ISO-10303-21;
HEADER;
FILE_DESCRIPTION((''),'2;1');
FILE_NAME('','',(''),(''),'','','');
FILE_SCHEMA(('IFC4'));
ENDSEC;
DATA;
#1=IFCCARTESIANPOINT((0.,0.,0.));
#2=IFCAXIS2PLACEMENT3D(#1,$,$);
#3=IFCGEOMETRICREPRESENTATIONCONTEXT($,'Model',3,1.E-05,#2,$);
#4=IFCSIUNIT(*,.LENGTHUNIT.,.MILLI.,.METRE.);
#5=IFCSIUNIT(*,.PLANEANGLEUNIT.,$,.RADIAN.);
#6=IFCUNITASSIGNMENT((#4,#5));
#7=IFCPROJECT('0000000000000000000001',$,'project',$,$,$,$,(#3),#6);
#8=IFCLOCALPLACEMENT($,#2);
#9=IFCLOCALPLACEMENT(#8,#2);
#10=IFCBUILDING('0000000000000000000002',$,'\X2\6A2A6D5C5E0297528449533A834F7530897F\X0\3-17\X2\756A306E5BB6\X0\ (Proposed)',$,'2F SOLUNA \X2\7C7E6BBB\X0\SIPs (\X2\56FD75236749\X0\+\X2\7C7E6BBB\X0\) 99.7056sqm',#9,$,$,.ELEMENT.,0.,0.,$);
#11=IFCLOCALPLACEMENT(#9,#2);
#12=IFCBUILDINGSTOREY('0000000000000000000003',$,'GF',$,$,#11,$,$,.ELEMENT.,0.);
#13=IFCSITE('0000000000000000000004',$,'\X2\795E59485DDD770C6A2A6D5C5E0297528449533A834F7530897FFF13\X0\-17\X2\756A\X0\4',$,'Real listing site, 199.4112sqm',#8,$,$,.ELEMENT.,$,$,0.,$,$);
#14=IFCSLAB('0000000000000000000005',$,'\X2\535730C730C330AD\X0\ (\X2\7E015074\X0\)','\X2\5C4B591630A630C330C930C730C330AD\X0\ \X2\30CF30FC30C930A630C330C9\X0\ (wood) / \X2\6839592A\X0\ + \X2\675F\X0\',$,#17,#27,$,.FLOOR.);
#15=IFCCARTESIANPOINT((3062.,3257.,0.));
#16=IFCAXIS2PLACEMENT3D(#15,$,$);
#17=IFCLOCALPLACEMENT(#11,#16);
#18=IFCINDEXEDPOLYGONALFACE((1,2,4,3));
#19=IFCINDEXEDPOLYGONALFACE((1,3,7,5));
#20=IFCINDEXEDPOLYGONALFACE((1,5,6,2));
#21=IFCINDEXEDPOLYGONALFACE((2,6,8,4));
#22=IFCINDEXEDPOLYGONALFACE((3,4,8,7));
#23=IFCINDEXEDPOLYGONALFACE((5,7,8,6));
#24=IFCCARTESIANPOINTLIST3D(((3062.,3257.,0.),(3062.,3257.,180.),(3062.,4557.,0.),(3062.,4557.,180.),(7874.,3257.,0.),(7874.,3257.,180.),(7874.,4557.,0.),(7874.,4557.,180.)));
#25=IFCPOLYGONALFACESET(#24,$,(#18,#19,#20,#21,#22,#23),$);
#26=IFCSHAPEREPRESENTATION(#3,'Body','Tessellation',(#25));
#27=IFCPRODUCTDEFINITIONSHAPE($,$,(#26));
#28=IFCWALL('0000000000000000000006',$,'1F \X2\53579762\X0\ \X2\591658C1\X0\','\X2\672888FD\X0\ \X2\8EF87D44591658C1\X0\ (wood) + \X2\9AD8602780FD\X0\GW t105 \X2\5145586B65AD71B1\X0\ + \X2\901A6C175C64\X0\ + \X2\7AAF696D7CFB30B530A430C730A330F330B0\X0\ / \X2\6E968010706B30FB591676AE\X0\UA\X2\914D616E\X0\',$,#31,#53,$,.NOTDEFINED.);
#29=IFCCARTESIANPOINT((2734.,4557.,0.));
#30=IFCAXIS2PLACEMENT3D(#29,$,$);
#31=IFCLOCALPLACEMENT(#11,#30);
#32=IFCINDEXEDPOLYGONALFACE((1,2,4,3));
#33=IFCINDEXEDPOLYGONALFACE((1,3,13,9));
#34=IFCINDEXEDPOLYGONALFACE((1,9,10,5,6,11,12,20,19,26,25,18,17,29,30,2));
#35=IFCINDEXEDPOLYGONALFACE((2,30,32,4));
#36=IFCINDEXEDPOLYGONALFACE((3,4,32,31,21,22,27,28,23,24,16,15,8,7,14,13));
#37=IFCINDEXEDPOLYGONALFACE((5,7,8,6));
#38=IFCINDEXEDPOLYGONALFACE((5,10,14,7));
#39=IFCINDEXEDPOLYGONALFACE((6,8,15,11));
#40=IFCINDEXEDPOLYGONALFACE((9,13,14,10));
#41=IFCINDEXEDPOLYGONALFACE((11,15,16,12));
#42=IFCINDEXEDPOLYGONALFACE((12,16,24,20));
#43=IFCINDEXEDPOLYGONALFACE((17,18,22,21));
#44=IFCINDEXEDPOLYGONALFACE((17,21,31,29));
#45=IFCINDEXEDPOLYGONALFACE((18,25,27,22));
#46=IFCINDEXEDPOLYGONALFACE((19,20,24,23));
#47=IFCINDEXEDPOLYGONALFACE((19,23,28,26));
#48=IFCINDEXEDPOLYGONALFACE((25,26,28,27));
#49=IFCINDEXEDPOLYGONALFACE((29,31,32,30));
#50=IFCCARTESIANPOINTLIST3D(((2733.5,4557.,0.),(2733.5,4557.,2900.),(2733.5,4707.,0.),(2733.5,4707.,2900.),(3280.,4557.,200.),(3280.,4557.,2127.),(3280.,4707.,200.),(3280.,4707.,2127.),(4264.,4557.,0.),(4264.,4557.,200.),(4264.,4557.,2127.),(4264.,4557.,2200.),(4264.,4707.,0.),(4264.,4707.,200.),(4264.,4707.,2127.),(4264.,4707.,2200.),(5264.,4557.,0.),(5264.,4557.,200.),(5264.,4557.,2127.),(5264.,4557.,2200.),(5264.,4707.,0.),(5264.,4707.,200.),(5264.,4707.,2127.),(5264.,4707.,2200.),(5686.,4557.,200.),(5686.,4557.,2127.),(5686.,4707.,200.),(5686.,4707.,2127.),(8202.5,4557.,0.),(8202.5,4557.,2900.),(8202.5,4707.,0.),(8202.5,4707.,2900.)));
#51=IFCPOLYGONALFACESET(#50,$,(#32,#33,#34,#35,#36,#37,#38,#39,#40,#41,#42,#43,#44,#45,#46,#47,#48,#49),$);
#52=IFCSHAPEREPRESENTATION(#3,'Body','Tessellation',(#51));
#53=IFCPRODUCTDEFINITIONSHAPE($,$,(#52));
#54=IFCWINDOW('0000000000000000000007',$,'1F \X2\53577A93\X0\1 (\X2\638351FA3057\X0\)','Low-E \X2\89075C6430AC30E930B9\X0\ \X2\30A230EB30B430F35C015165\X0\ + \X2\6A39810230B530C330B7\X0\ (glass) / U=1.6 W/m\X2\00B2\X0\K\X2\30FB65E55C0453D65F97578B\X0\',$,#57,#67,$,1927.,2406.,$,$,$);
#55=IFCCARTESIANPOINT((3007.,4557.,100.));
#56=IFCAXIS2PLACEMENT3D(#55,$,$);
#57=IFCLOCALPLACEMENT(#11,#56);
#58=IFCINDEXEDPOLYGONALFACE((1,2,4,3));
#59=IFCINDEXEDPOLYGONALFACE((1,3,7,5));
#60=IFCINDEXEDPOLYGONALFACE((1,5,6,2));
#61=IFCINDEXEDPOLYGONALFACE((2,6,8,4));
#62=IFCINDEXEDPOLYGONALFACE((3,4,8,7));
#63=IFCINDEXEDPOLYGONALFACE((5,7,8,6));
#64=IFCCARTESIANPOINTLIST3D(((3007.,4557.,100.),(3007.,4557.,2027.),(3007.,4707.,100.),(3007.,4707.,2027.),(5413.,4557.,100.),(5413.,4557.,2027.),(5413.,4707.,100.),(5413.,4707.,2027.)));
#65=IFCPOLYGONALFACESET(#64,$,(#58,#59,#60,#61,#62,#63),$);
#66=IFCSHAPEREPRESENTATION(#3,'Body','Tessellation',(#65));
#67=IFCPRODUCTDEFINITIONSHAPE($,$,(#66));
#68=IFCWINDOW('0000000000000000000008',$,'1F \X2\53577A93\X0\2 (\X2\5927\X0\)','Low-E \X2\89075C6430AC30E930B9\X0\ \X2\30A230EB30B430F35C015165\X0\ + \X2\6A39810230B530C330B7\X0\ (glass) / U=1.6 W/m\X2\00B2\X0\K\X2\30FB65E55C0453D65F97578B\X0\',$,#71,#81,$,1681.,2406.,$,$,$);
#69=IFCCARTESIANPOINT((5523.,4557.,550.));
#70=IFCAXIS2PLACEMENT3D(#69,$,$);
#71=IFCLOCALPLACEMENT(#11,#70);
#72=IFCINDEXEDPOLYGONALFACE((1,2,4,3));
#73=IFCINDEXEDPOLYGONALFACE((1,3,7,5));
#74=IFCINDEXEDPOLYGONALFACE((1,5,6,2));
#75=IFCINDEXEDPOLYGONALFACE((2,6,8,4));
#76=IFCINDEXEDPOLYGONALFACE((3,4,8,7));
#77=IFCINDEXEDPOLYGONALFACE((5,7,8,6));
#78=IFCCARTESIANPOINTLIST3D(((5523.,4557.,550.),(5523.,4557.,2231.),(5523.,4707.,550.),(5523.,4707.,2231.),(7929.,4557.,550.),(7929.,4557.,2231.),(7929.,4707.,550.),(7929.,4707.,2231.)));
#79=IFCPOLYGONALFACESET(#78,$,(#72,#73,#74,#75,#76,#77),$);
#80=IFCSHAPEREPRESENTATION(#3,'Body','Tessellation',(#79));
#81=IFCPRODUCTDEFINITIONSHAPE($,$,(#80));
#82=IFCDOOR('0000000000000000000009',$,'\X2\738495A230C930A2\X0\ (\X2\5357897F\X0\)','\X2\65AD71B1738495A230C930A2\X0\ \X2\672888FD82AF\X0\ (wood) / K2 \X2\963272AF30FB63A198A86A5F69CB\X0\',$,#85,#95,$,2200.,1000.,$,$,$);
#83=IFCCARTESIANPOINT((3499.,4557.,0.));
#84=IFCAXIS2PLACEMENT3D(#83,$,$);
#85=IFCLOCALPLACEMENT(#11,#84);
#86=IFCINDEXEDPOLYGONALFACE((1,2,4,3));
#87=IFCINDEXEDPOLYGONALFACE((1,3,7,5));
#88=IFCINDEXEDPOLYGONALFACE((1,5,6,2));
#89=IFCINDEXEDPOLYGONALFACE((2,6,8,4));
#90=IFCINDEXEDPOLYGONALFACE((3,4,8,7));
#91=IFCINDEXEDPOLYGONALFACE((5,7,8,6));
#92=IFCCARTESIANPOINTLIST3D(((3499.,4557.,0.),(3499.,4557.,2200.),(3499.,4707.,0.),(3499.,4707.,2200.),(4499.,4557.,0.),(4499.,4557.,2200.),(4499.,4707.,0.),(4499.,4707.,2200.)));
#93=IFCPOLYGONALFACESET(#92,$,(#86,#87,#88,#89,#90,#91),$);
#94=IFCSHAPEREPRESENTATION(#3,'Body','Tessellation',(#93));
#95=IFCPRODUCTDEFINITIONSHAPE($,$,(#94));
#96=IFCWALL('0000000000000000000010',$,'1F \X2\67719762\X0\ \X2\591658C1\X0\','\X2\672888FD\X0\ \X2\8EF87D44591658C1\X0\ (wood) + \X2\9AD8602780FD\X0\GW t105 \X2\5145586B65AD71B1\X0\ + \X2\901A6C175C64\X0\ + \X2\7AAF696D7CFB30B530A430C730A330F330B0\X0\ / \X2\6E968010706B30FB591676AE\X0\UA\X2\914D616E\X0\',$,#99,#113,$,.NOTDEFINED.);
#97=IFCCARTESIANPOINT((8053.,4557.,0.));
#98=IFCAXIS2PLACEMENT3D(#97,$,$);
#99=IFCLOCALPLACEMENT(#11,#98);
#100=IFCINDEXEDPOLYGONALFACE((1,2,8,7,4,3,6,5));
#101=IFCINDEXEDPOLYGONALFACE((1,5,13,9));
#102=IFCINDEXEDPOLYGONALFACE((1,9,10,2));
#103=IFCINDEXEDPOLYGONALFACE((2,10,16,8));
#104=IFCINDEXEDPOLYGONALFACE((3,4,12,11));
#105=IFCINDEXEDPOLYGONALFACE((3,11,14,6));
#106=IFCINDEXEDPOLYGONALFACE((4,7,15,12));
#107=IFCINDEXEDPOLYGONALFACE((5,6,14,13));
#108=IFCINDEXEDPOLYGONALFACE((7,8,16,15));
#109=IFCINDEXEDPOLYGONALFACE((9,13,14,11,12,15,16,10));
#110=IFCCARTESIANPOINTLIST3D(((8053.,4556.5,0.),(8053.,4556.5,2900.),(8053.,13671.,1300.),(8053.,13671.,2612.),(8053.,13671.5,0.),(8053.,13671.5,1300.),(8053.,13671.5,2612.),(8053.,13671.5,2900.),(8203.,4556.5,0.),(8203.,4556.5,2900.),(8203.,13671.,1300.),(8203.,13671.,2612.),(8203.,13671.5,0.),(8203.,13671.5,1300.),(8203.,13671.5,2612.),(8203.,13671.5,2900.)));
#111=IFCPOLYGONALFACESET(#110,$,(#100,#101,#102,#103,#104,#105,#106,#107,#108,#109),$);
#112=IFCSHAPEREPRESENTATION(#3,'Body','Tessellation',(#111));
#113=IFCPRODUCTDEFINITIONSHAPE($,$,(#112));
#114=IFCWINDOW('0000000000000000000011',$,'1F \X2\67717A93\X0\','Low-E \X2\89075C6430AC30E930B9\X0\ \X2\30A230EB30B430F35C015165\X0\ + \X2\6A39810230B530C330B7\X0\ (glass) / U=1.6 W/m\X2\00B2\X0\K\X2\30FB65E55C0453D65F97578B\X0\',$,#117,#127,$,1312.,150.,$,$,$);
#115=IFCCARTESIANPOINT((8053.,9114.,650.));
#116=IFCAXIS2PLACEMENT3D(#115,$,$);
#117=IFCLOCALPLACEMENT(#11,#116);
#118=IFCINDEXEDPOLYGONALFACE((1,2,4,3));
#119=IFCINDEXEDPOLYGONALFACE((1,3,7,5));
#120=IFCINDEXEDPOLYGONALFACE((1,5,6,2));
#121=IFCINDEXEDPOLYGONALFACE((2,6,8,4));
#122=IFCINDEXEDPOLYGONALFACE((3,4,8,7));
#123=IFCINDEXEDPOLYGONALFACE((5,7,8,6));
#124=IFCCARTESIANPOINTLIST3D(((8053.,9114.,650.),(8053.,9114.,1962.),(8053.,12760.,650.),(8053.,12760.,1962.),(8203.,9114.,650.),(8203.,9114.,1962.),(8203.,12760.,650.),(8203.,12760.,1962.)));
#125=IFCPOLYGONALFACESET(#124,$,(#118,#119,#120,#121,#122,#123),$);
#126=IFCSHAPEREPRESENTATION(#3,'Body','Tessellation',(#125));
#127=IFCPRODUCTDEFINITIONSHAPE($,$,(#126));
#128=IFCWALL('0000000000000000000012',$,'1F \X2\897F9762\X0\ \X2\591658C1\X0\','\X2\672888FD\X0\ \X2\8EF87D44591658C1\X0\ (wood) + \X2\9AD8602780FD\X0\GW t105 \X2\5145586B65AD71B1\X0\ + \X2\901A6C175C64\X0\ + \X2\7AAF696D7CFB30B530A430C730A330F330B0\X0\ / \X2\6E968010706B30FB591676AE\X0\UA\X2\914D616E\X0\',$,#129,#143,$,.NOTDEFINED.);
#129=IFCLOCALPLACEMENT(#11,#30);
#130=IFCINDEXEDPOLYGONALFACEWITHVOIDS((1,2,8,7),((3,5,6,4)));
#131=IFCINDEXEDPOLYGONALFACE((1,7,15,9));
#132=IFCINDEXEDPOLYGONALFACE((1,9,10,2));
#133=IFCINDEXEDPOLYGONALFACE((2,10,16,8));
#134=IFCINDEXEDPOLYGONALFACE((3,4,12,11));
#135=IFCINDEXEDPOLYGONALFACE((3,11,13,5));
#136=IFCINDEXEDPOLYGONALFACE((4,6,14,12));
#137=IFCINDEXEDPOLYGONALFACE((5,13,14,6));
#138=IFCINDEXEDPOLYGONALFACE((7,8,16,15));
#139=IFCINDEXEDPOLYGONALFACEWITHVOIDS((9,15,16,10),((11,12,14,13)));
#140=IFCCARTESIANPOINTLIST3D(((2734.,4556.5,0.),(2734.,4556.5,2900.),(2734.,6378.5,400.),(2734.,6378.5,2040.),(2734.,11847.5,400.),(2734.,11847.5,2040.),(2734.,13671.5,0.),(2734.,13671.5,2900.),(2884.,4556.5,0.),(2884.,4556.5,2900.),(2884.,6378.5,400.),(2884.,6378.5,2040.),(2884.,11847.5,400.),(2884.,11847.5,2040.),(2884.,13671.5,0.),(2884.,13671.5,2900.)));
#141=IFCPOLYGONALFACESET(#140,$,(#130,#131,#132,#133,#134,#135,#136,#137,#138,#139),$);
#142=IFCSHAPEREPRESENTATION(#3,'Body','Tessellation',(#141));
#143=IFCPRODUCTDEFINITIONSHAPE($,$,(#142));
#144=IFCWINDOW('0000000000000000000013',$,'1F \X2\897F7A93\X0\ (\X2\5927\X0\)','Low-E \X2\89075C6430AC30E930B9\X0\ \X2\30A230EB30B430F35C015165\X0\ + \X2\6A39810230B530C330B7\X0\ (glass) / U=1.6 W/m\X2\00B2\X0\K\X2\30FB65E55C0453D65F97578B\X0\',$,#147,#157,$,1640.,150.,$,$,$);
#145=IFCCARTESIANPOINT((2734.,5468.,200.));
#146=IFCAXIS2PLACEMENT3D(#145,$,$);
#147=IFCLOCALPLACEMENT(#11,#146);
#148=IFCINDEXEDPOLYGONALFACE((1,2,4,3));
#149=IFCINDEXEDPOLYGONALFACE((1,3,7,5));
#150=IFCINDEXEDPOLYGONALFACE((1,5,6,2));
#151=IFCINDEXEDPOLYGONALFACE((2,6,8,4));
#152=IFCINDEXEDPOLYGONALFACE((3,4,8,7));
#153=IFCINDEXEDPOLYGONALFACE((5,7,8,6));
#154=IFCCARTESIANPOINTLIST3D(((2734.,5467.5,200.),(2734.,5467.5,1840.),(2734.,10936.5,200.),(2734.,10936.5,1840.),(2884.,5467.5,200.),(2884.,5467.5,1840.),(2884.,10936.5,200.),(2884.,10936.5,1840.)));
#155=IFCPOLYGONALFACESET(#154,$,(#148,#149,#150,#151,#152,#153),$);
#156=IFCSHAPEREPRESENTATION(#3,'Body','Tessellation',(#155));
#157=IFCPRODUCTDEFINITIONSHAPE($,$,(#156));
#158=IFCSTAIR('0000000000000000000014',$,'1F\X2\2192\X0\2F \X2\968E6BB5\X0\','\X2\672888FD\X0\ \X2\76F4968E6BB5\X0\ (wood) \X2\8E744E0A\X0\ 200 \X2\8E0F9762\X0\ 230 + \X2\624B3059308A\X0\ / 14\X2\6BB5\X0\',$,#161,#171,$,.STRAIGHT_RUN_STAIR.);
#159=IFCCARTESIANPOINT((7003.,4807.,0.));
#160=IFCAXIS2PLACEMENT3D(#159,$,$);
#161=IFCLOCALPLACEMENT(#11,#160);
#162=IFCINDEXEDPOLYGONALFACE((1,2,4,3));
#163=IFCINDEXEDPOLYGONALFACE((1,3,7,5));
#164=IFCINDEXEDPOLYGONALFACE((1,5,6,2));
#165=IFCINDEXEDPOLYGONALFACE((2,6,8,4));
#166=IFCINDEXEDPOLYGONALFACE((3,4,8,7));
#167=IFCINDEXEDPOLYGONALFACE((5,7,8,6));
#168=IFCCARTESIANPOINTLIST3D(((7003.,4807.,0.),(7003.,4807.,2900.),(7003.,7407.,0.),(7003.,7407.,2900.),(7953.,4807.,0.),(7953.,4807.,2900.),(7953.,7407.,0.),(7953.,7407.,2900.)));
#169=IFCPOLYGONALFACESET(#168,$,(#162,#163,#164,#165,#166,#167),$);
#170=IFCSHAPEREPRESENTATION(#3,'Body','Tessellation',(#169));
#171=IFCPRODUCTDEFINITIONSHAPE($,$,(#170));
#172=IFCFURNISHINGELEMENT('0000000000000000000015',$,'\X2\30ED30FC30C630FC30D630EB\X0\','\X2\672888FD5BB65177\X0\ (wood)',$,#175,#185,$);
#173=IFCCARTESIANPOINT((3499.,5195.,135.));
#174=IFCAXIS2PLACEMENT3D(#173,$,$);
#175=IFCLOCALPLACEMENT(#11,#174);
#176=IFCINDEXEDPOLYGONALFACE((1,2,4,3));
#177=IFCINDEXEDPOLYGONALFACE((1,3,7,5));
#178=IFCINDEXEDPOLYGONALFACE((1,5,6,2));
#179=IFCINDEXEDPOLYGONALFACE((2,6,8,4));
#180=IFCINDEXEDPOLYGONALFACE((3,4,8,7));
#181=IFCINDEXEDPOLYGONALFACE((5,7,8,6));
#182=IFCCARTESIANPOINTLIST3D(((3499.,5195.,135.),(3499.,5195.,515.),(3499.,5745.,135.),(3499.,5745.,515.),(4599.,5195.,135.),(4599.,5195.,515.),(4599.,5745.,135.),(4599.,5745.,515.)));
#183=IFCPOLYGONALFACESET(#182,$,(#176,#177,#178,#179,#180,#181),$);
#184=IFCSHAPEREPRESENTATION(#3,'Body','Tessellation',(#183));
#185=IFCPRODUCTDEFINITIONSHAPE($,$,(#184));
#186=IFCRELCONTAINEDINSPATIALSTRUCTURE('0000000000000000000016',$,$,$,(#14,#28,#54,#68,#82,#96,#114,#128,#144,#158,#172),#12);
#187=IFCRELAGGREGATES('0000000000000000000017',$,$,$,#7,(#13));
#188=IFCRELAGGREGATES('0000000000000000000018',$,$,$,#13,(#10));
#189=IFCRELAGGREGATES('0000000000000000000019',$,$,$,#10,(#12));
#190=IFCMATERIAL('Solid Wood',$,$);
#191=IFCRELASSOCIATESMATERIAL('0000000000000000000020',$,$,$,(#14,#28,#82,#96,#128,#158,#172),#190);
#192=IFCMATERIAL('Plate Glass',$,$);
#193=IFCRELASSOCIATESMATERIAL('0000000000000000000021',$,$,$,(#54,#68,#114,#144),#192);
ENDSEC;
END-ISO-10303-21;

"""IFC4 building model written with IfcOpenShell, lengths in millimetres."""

from ifc_helpers import new_model, si_unit, frame, frame_2d, origin, place, context, project, spatial, rectangle, extrude, material, element, fill, save


model = new_model("IFC4")

# Units and contexts
model_context = context("Model", 3, precision=1e-05, world=origin())
ifc_project = project(units=[si_unit("LENGTHUNIT", "METRE", prefix="MILLI"), si_unit("PLANEANGLEUNIT", "RADIAN")], contexts=[model_context])

# Site, building, storey
site_placement = place(None, origin())
site = spatial("IfcSite", under=ifc_project, at=site_placement, Name="神奈川県横浜市青葉区荏田西３-17番4", ObjectType="Real listing site, 199.4112sqm", CompositionType="ELEMENT", RefElevation=0.0)
building_placement = place(site_placement, origin())
building = spatial("IfcBuilding", under=site, at=building_placement, Name="横浜市青葉区荏田西3-17番の家 (Proposed)", ObjectType="2F SOLUNA 籾殻SIPs (国産杉+籾殻) 99.7056sqm", CompositionType="ELEMENT", ElevationOfRefHeight=0.0, ElevationOfTerrain=0.0)
storey_placement = place(building_placement, origin())
storey = spatial("IfcBuildingStorey", under=building, at=storey_placement, Name="GF", CompositionType="ELEMENT", Elevation=0.0)

# Slab
ifc_material_1 = material(Name="Solid Wood")
slab_1_placement = place(storey_placement, frame((3062.0, 3257.0, 0.0)))
element("IfcSlab", 1, at=slab_1_placement, inside=storey, material=ifc_material_1, Name="南デッキ (縁側)", Description="屋外ウッドデッキ ハードウッド (wood) / 根太 + 束", PredefinedType="FLOOR", context=model_context, shape_type="SweptSolid", body=[
    extrude(rectangle(XDim=4812.0, YDim=1300.0, at=frame_2d((2406.0, 650.0))), frame((3062.0, 3257.0, 0.0)), (0.0, 0.0, 1.0), 180.0),
])

# Wall, openings, windows, door
wall_1_placement = place(storey_placement, frame((2734.0, 4557.0, 0.0)))
wall_1 = element("IfcWall", 2, at=wall_1_placement, inside=storey, material=ifc_material_1, Name="1F 南面 外壁", Description="木製 軸組外壁 (wood) + 高性能GW t105 充填断熱 + 通気層 + 窯業系サイディング / 準耐火・外皮UA配慮", PredefinedType="NOTDEFINED", context=model_context, shape_type="SweptSolid", body=[
    extrude(rectangle(XDim=5469.0, YDim=150.0, at=frame_2d((2734.0, 75.0))), frame((2734.0, 4557.0, 0.0)), (0.0, 0.0, 1.0), 2900.0),
])
opening_1_placement = place(storey_placement, frame((3007.0, 4557.0, 100.0)))
opening_1 = element("IfcOpeningElement", 3, at=opening_1_placement, cuts=wall_1, PredefinedType="NOTDEFINED", context=model_context, shape_type="SweptSolid", body=[
    extrude(rectangle(XDim=2406.0, YDim=150.0, at=frame_2d((1203.0, 75.0))), frame((3007.0, 4557.0, 100.0)), (0.0, 0.0, 1.0), 1927.0),
])
opening_2_placement = place(storey_placement, frame((5523.0, 4557.0, 550.0)))
opening_2 = element("IfcOpeningElement", 4, at=opening_2_placement, cuts=wall_1, PredefinedType="NOTDEFINED", context=model_context, shape_type="SweptSolid", body=[
    extrude(rectangle(XDim=2406.0, YDim=150.0, at=frame_2d((1203.0, 75.0))), frame((5523.0, 4557.0, 550.0)), (0.0, 0.0, 1.0), 1681.0),
])
opening_3_placement = place(storey_placement, frame((3499.0, 4557.0, 0.0)))
opening_3 = element("IfcOpeningElement", 5, at=opening_3_placement, cuts=wall_1, PredefinedType="NOTDEFINED", context=model_context, shape_type="SweptSolid", body=[
    extrude(rectangle(XDim=1000.0, YDim=150.0, at=frame_2d((500.0, 75.0))), frame((3499.0, 4557.0, 0.0)), (0.0, 0.0, 1.0), 2200.0),
])
ifc_material_2 = material(Name="Plate Glass")
window_1_placement = place(storey_placement, frame((3007.0, 4557.0, 100.0)))
window_1 = element("IfcWindow", 6, at=window_1_placement, inside=storey, material=ifc_material_2, Name="1F 南窓1 (掃出し)", Description="Low-E 複層ガラス アルゴン封入 + 樹脂サッシ (glass) / U=1.6 W/m²K・日射取得型", OverallHeight=1927.0, OverallWidth=2406.0, context=model_context, shape_type="SweptSolid", body=[
    extrude(rectangle(XDim=2406.0, YDim=150.0, at=frame_2d((1203.0, 75.0))), frame((3007.0, 4557.0, 100.0)), (0.0, 0.0, 1.0), 1927.0),
])
fill(opening_1, window_1)
window_2_placement = place(storey_placement, frame((5523.0, 4557.0, 550.0)))
window_2 = element("IfcWindow", 7, at=window_2_placement, inside=storey, material=ifc_material_2, Name="1F 南窓2 (大)", Description="Low-E 複層ガラス アルゴン封入 + 樹脂サッシ (glass) / U=1.6 W/m²K・日射取得型", OverallHeight=1681.0, OverallWidth=2406.0, context=model_context, shape_type="SweptSolid", body=[
    extrude(rectangle(XDim=2406.0, YDim=150.0, at=frame_2d((1203.0, 75.0))), frame((5523.0, 4557.0, 550.0)), (0.0, 0.0, 1.0), 1681.0),
])
fill(opening_2, window_2)
door_placement = place(storey_placement, frame((3499.0, 4557.0, 0.0)))
door = element("IfcDoor", 8, at=door_placement, inside=storey, material=ifc_material_1, Name="玄関ドア (南西)", Description="断熱玄関ドア 木製芯 (wood) / K2 防犯・採風機構", OverallHeight=2200.0, OverallWidth=1000.0, context=model_context, shape_type="SweptSolid", body=[
    extrude(rectangle(XDim=1000.0, YDim=150.0, at=frame_2d((500.0, 75.0))), frame((3499.0, 4557.0, 0.0)), (0.0, 0.0, 1.0), 2200.0),
])
fill(opening_3, door)

# Walls, openings, windows
wall_2_placement = place(storey_placement, frame((8053.0, 4557.0, 0.0)))
wall_2 = element("IfcWall", 9, at=wall_2_placement, inside=storey, material=ifc_material_1, Name="1F 東面 外壁", Description="木製 軸組外壁 (wood) + 高性能GW t105 充填断熱 + 通気層 + 窯業系サイディング / 準耐火・外皮UA配慮", PredefinedType="NOTDEFINED", context=model_context, shape_type="SweptSolid", body=[
    extrude(rectangle(XDim=150.0, YDim=9115.0, at=frame_2d((75.0, 4557.0))), frame((8053.0, 4557.0, 0.0)), (0.0, 0.0, 1.0), 2900.0),
])
opening_4_placement = place(storey_placement, frame((8053.0, 9114.0, 650.0)))
opening_4 = element("IfcOpeningElement", 10, at=opening_4_placement, cuts=wall_2, PredefinedType="NOTDEFINED", context=model_context, shape_type="SweptSolid", body=[
    extrude(rectangle(XDim=150.0, YDim=3646.0, at=frame_2d((75.0, 1823.0))), frame((8053.0, 9114.0, 650.0)), (0.0, 0.0, 1.0), 1312.0),
])
window_3_placement = place(storey_placement, frame((8053.0, 9114.0, 650.0)))
window_3 = element("IfcWindow", 11, at=window_3_placement, inside=storey, material=ifc_material_2, Name="1F 東窓", Description="Low-E 複層ガラス アルゴン封入 + 樹脂サッシ (glass) / U=1.6 W/m²K・日射取得型", OverallHeight=1312.0, OverallWidth=150.0, context=model_context, shape_type="SweptSolid", body=[
    extrude(rectangle(XDim=150.0, YDim=3646.0, at=frame_2d((75.0, 1823.0))), frame((8053.0, 9114.0, 650.0)), (0.0, 0.0, 1.0), 1312.0),
])
fill(opening_4, window_3)
wall_3_placement = place(storey_placement, frame((2734.0, 4557.0, 0.0)))
wall_3 = element("IfcWall", 12, at=wall_3_placement, inside=storey, material=ifc_material_1, Name="1F 西面 外壁", Description="木製 軸組外壁 (wood) + 高性能GW t105 充填断熱 + 通気層 + 窯業系サイディング / 準耐火・外皮UA配慮", PredefinedType="NOTDEFINED", context=model_context, shape_type="SweptSolid", body=[
    extrude(rectangle(XDim=150.0, YDim=9115.0, at=frame_2d((75.0, 4557.0))), frame((2734.0, 4557.0, 0.0)), (0.0, 0.0, 1.0), 2900.0),
])
opening_5_placement = place(storey_placement, frame((2734.0, 5468.0, 200.0)))
opening_5 = element("IfcOpeningElement", 13, at=opening_5_placement, cuts=wall_3, PredefinedType="NOTDEFINED", context=model_context, shape_type="SweptSolid", body=[
    extrude(rectangle(XDim=150.0, YDim=5469.0, at=frame_2d((75.0, 2734.0))), frame((2734.0, 5468.0, 200.0)), (0.0, 0.0, 1.0), 1640.0),
])
window_4_placement = place(storey_placement, frame((2734.0, 5468.0, 200.0)))
window_4 = element("IfcWindow", 14, at=window_4_placement, inside=storey, material=ifc_material_2, Name="1F 西窓 (大)", Description="Low-E 複層ガラス アルゴン封入 + 樹脂サッシ (glass) / U=1.6 W/m²K・日射取得型", OverallHeight=1640.0, OverallWidth=150.0, context=model_context, shape_type="SweptSolid", body=[
    extrude(rectangle(XDim=150.0, YDim=5469.0, at=frame_2d((75.0, 2734.0))), frame((2734.0, 5468.0, 200.0)), (0.0, 0.0, 1.0), 1640.0),
])
fill(opening_5, window_4)

# Stair
stair_placement = place(storey_placement, frame((7003.0, 4807.0, 0.0)))
element("IfcStair", 15, at=stair_placement, inside=storey, material=ifc_material_1, Name="1F→2F 階段", Description="木製 直階段 (wood) 蹴上 200 踏面 230 + 手すり / 14段", PredefinedType="STRAIGHT_RUN_STAIR", context=model_context, shape_type="SweptSolid", body=[
    extrude(rectangle(XDim=950.0, YDim=2600.0, at=frame_2d((475.0, 1300.0))), frame((7003.0, 4807.0, 0.0)), (0.0, 0.0, 1.0), 2900.0),
])

# Furnishing element
furnishing_1_placement = place(storey_placement, frame((3499.0, 5195.0, 135.0)))
element("IfcFurnishingElement", 16, at=furnishing_1_placement, inside=storey, material=ifc_material_1, Name="ローテーブル", Description="木製家具 (wood)", context=model_context, shape_type="SweptSolid", body=[
    extrude(rectangle(XDim=1100.0, YDim=550.0, at=frame_2d((550.0, 275.0))), frame((3499.0, 5195.0, 135.0)), (0.0, 0.0, 1.0), 380.0),
])

save(model, "model.ifc")
